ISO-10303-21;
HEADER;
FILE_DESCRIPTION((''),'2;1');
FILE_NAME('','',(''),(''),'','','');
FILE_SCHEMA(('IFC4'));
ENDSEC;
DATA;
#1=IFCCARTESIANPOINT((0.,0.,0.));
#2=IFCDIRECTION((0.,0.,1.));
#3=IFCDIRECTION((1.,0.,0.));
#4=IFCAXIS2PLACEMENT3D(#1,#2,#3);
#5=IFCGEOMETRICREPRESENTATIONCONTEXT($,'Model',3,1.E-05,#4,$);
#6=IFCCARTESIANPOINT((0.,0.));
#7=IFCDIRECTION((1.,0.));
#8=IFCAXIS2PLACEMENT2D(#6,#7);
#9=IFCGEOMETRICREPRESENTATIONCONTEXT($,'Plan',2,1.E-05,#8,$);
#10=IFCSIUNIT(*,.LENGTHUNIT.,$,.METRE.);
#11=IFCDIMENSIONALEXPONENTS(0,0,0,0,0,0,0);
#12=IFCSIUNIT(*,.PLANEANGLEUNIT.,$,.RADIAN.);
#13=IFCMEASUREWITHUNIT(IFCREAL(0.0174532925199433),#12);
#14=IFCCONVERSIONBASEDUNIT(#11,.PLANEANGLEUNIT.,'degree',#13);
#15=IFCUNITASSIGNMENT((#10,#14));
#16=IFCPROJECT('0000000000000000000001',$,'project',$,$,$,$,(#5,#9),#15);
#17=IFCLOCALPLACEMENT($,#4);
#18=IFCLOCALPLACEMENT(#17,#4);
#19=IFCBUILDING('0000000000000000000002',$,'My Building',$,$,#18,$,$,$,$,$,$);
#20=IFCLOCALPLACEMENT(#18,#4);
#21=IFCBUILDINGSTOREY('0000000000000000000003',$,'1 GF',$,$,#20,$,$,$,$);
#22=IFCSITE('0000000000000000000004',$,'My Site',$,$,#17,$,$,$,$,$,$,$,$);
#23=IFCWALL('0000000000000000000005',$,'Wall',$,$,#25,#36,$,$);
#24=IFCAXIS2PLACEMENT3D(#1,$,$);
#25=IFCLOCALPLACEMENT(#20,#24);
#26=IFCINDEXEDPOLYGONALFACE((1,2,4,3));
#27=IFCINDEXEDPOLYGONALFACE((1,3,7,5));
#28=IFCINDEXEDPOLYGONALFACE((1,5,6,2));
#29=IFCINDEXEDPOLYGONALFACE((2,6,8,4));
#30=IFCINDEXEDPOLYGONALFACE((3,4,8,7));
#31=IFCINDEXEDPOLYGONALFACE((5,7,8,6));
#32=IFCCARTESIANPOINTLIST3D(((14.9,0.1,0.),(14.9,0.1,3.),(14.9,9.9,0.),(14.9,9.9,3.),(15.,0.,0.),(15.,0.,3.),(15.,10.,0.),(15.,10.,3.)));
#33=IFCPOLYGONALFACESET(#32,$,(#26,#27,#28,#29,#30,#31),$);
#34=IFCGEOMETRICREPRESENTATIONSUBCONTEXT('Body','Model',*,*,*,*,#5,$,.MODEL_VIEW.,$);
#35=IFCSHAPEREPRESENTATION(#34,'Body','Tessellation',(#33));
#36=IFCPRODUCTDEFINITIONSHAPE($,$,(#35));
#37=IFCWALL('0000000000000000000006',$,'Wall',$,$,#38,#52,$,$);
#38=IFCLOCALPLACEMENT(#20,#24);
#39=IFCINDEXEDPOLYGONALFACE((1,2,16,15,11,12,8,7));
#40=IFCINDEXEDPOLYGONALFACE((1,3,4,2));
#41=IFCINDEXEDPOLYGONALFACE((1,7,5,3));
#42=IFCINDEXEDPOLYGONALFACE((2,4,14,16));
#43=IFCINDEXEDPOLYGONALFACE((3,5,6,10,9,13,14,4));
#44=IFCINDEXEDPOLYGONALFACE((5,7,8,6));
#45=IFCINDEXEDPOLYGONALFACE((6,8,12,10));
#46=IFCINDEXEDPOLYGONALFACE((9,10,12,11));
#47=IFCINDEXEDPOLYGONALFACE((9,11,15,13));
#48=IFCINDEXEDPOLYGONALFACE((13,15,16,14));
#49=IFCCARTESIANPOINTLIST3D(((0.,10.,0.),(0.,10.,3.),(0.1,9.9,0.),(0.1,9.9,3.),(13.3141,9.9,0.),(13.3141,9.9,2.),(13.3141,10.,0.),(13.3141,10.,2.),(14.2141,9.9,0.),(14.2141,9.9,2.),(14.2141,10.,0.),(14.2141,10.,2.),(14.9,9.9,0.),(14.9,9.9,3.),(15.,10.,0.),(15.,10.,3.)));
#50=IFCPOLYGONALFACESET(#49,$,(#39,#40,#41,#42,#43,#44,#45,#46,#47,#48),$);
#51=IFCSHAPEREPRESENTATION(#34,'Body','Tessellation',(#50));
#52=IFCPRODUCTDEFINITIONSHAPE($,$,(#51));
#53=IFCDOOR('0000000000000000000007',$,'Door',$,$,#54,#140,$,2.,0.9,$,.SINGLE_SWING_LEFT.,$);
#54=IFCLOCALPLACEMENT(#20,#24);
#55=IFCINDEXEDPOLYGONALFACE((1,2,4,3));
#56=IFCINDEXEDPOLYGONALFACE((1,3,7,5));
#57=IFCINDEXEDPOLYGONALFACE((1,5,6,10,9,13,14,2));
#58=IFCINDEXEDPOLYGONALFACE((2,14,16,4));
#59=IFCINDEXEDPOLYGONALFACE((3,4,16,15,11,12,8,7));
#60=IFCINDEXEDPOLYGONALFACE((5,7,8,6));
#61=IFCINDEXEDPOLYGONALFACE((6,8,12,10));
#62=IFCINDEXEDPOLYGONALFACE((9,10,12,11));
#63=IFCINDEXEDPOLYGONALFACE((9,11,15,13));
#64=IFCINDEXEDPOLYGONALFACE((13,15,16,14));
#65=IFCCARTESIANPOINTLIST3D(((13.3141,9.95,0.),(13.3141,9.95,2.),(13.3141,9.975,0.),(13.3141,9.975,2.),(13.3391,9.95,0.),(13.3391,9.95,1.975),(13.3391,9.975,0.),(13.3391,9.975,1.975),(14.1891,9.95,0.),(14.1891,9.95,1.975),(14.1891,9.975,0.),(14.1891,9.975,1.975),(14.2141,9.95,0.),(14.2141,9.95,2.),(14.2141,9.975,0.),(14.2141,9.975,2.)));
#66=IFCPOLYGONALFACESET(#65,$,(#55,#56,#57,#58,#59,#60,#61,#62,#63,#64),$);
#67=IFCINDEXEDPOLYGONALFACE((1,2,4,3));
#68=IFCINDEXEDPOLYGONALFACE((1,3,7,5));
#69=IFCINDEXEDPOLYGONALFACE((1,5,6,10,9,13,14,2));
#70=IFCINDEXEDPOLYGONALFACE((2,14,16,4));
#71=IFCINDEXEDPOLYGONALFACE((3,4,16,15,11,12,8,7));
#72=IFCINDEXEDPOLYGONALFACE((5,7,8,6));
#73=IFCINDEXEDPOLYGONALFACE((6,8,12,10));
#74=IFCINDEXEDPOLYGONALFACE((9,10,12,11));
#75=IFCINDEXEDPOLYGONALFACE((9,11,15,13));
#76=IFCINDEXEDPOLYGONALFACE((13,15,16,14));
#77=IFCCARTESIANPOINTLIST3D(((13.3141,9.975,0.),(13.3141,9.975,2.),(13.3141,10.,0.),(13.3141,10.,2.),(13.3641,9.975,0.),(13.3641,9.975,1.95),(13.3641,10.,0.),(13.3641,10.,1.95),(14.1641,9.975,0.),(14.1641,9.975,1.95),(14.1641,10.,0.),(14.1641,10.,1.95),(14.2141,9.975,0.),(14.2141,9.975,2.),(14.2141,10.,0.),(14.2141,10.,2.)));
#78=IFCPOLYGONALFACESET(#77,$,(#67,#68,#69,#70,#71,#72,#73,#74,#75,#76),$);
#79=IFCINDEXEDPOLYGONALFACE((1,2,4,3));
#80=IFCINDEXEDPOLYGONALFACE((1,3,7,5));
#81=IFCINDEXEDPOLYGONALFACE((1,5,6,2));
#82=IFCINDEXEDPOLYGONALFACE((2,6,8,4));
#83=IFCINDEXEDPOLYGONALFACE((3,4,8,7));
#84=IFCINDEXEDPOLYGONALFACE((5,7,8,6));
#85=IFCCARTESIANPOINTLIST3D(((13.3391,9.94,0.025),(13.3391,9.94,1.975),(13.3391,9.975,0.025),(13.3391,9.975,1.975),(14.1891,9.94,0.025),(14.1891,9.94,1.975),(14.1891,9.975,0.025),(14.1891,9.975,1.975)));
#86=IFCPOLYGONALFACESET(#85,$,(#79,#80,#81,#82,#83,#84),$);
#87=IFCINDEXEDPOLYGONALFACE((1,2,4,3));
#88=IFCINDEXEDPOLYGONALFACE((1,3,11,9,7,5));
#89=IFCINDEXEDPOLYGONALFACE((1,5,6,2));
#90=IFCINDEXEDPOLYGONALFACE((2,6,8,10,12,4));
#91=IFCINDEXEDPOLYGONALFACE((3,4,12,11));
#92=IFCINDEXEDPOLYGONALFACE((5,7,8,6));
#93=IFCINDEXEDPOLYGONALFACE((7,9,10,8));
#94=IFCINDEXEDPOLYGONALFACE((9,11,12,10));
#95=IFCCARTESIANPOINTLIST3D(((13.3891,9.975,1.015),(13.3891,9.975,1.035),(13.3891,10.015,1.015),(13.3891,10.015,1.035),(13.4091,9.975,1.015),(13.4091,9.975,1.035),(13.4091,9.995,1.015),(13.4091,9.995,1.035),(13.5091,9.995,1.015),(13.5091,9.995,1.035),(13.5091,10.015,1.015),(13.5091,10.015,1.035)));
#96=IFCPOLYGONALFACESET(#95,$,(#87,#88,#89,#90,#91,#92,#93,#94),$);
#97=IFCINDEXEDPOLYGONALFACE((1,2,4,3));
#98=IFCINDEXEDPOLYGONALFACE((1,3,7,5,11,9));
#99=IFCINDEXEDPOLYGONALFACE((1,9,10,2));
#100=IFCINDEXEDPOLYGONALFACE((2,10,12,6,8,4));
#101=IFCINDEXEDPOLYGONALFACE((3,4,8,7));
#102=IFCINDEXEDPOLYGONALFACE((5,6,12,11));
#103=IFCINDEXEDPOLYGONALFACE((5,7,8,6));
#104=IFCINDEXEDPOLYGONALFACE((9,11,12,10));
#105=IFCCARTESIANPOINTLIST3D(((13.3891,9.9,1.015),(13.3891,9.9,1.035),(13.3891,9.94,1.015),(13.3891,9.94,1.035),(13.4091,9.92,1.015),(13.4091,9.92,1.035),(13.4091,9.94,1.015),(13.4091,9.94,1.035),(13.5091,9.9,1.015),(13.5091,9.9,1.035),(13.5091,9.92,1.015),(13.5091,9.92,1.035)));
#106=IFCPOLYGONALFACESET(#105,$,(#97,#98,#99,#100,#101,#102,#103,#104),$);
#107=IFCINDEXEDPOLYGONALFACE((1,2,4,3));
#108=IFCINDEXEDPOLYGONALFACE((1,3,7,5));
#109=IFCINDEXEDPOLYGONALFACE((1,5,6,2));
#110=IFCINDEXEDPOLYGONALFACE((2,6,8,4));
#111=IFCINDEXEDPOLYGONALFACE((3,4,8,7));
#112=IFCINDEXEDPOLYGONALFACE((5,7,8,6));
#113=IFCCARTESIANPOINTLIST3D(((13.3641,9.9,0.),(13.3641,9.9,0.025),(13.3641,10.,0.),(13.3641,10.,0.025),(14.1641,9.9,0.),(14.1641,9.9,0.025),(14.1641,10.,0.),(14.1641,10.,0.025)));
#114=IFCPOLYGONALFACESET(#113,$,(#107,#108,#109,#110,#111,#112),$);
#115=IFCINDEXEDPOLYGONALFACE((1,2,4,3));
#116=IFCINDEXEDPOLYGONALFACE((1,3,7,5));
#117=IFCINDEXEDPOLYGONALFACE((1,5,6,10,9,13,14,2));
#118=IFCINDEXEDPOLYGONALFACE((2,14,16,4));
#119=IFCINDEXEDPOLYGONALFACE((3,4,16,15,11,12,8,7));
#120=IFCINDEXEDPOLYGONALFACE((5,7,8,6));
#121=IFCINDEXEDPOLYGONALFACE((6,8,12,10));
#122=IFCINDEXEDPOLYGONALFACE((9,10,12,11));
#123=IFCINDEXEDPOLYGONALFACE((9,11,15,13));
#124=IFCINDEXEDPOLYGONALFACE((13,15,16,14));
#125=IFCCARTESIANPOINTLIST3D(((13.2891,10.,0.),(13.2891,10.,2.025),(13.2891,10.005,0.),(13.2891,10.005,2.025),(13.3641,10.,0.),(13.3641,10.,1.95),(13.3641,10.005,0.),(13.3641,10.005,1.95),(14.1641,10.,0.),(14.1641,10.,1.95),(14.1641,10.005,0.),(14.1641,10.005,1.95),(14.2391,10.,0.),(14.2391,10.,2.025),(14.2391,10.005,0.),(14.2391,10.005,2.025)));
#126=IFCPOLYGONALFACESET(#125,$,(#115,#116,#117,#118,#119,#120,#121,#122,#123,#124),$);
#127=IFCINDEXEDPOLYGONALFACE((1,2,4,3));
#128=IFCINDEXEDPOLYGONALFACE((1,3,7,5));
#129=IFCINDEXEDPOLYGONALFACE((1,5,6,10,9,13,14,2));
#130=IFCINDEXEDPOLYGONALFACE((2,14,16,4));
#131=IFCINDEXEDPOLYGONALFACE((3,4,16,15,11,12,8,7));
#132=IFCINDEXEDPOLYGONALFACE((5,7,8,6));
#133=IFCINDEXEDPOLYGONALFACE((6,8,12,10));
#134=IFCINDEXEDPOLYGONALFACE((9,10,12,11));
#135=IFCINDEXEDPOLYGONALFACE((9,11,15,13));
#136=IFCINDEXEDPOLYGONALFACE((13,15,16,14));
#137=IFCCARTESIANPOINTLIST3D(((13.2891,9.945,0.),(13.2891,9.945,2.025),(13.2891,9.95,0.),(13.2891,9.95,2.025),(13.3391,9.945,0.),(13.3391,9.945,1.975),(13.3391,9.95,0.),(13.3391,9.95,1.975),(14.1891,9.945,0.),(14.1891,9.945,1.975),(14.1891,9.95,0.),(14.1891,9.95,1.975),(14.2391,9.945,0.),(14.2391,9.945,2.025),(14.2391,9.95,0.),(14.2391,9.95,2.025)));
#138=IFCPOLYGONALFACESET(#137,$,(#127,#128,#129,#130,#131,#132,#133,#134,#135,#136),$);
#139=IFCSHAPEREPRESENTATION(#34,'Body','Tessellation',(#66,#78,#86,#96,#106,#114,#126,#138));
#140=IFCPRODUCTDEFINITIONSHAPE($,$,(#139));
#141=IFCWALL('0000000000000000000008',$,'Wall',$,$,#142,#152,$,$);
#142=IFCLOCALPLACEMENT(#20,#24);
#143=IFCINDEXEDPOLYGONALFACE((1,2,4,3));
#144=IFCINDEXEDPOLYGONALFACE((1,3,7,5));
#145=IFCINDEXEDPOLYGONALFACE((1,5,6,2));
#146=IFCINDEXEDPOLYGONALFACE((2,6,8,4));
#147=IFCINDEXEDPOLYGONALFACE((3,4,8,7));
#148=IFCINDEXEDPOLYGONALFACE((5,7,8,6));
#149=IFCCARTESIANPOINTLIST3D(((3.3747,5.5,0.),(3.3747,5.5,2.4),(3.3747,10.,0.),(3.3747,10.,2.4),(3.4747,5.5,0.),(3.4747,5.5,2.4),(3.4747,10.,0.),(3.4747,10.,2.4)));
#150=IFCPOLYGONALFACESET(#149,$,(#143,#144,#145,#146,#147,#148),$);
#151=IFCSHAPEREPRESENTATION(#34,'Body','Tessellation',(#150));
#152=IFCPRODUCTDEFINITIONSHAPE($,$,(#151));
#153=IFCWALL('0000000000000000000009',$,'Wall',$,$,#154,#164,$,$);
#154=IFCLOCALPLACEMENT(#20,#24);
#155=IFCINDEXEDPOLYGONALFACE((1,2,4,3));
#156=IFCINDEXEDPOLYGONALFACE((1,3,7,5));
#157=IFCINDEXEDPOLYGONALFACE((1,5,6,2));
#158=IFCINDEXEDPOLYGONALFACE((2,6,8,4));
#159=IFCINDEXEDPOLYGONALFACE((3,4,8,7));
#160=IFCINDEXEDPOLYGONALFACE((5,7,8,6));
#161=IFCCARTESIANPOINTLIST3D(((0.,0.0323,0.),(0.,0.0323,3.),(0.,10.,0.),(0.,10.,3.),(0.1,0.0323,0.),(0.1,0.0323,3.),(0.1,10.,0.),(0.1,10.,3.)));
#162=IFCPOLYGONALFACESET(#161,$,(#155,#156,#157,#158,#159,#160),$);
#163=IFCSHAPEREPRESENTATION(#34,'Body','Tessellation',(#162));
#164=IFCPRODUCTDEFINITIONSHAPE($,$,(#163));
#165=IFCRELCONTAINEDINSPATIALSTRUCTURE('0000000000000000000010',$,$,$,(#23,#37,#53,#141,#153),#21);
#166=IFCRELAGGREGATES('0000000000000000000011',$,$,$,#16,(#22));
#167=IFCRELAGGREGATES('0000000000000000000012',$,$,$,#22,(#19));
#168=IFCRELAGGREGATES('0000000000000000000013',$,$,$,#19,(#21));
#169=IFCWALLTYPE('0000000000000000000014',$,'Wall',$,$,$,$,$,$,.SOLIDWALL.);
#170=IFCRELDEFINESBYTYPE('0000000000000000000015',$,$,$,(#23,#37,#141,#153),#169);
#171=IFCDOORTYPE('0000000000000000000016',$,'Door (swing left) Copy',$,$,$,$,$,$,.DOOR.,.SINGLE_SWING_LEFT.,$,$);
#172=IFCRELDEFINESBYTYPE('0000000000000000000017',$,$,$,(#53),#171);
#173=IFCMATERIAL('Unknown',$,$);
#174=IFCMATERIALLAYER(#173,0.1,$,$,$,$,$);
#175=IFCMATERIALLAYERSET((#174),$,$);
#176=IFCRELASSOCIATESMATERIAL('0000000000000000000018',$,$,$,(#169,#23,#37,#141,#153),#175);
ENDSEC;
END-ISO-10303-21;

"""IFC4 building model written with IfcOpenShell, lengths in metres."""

from ifc_helpers import new_model, entity, si_unit, converted_unit, frame, origin_with_axes, origin_2d_with_axis, place, context, subcontext, project, spatial, line, indexed_curve, outline, extrude, shape, source, transform, mapped, material, layer, layer_set, layer_usage, type_object, type_shapes, element, fill, save


model = new_model("IFC4")

# Units and contexts
model_context = context("Model", 3, precision=1e-05, world=origin_with_axes())
plan_context = context("Plan", 2, precision=1e-05, world=origin_2d_with_axis())
body_context_1 = subcontext(model_context, "Body", "Model", "MODEL_VIEW")
body_context_2 = subcontext(plan_context, "Body", "Plan", "PLAN_VIEW")
ifc_project = project(units=[si_unit("LENGTHUNIT", "METRE"), converted_unit("PLANEANGLEUNIT", "degree", entity("IfcReal", 0.0174532925199433), si_unit("PLANEANGLEUNIT", "RADIAN"), dimensions=[0, 0, 0, 0, 0, 0, 0])], contexts=[model_context, plan_context])

# Site, building, storey
site_placement = place(None, origin_with_axes())
site = spatial("IfcSite", under=ifc_project, at=site_placement, Name="My Site")
building_placement = place(site_placement, origin_with_axes())
building = spatial("IfcBuilding", under=site, at=building_placement, Name="My Building")
storey_placement = place(building_placement, origin_with_axes())
storey = spatial("IfcBuildingStorey", under=building, at=storey_placement, Name="1 GF")

# Shared definitions
ifc_material = material(Name="Unknown")

# Shared definitions
ifc_layer_1 = layer(ifc_material, 0.1)
ifc_layer_set_1 = layer_set([ifc_layer_1])
wall_type = type_object("IfcWallType", Name="Wall", PredefinedType="SOLIDWALL", material=ifc_layer_set_1)

# Wall
ifc_layer_usage_1 = layer_usage(ifc_layer_set_1, "AXIS2", "POSITIVE", 0.0)
wall_1_placement = place(storey_placement, frame((15.0, 0.0, 0.0), z_axis=(0.0, 0.0, 1.0), x_axis=(0.0, 1.0, 0.0)))
element("IfcWall", 1, at=wall_1_placement, inside=storey, type_object=wall_type, material=ifc_layer_usage_1, Name="Wall", context=body_context_1, shape_type="SweptSolid", body=[
    extrude(outline(indexed_curve([(0.0, 0.0), (0.1, 0.1), (9.9, 0.1), (10.0, 0.0)], segments=[line(1, 2, 3, 4, 1)])), origin_with_axes(), (0.0, 0.0, 1.0), 3.0),
])

# Wall, opening, door
ifc_layer_usage_2 = layer_usage(ifc_layer_set_1, "AXIS2", "POSITIVE", 0.0)
wall_2_placement = place(storey_placement, frame((15.0, 10.0, 0.0), z_axis=(0.0, 0.0, 1.0), x_axis=(-1.0, 0.0, 0.0)))
wall_2 = element("IfcWall", 2, at=wall_2_placement, inside=storey, type_object=wall_type, material=ifc_layer_usage_2, Name="Wall", context=body_context_1, shape_type="SweptSolid", body=[
    extrude(outline(indexed_curve([(0.0, 0.0), (0.1, 0.1), (14.9, 0.1), (15.0, 0.0)], segments=[line(1, 2, 3, 4, 1)])), origin_with_axes(), (0.0, 0.0, 1.0), 3.0),
])
shared_shape_1 = source(origin_with_axes(), body_context_1, "Body", "SweptSolid", [
    extrude(outline(indexed_curve([(0.0, 0.0), (0.9, 0.0), (0.9, 2.0), (0.0, 2.0)], segments=[line(1, 2, 3, 4, 1)])), frame((0.0, -0.6, 0.0), z_axis=(0.0, -1.0, 0.0), x_axis=(1.0, 0.0, 0.0)), (0.0, 0.0, -1.0), 1.2),
])
opening_1_placement = place(wall_2_placement, frame((0.7859, 0.0, 0.0), z_axis=(0.0, 0.0, 1.0), x_axis=(1.0, 0.0, 0.0)))
opening_1 = element("IfcOpeningElement", 3, at=opening_1_placement, cuts=wall_2, PredefinedType="OPENING", context=body_context_1, shape_type="MappedRepresentation", body=[
    mapped(shared_shape_1, transform((0.0, 0.0, 0.0), x_axis=(1.0, 0.0, 0.0), y_axis=(0.0, 1.0, 0.0), z_axis=(0.0, 0.0, 1.0), scale=1.0)),
])
door_type_1 = type_object("IfcDoorType", Name="Door (swing left) Copy", OperationType="SINGLE_SWING_LEFT", PredefinedType="DOOR")
shared_shape_2 = source(origin_with_axes(), body_context_1, "Body", "SweptSolid", [
    extrude(outline(indexed_curve([(0.0, 0.0), (0.0, 2.0), (0.9, 2.0), (0.9, 0.0), (0.875, 0.0), (0.875, 1.975), (0.025, 1.975), (0.025, 0.0)], segments=[line(1, 2, 3, 4, 5, 6, 7, 8, 1)])), frame((0.0, 0.025, 0.0), z_axis=(0.0, -1.0, 0.0), x_axis=(1.0, 0.0, 0.0)), (0.0, 0.0, -1.0), 0.025),
    extrude(outline(indexed_curve([(0.0, 0.0), (0.0, 2.0), (0.9, 2.0), (0.9, 0.0), (0.85, 0.0), (0.85, 1.95), (0.05, 1.95), (0.05, 0.0)], segments=[line(1, 2, 3, 4, 5, 6, 7, 8, 1)])), frame((0.0, 0.0, 0.0), z_axis=(0.0, -1.0, 0.0), x_axis=(1.0, 0.0, 0.0)), (0.0, 0.0, -1.0), 0.025),
    extrude(outline(indexed_curve([(0.0, 0.0), (0.85, 0.0), (0.85, 0.035), (0.0, 0.035)], segments=[line(1, 2, 3, 4, 1)])), frame((0.025, 0.025, 0.025), z_axis=(0.0, 0.0, 1.0), x_axis=(1.0, 0.0, 0.0)), (0.0, 0.0, 1.0), 1.95),
    extrude(outline(indexed_curve([(0.0, 0.0), (0.0, -0.04), (-0.12, -0.04), (-0.12, -0.02), (-0.02, -0.02), (-0.02, 0.0)], segments=[line(1, 2, 3, 4, 5, 6, 1)])), frame((0.825, 0.025, 1.015), z_axis=(0.0, 0.0, 1.0), x_axis=(1.0, 0.0, 0.0)), (0.0, 0.0, 1.0), 0.02),
    extrude(outline(indexed_curve([(0.0, 0.0), (0.0, 0.04), (-0.12, 0.04), (-0.12, 0.02), (-0.02, 0.02), (-0.02, 0.0)], segments=[line(1, 2, 3, 4, 5, 6, 1)])), frame((0.825, 0.06, 1.015), z_axis=(0.0, 0.0, 1.0), x_axis=(1.0, 0.0, 0.0)), (0.0, 0.0, 1.0), 0.02),
    extrude(outline(indexed_curve([(0.0, 0.0), (0.8, 0.0), (0.8, 0.1), (0.0, 0.1)], segments=[line(1, 2, 3, 4, 1)])), frame((0.05, 0.0, 0.0), z_axis=(0.0, 0.0, 1.0), x_axis=(1.0, 0.0, 0.0)), (0.0, 0.0, 1.0), 0.025),
    extrude(outline(indexed_curve([(0.0, 0.0), (0.0, 2.025), (0.95, 2.025), (0.95, 0.0), (0.875, 0.0), (0.875, 1.95), (0.075, 1.95), (0.075, 0.0)], segments=[line(1, 2, 3, 4, 5, 6, 7, 8, 1)])), frame((-0.025, -0.005, 0.0), z_axis=(0.0, -1.0, 0.0), x_axis=(1.0, 0.0, 0.0)), (0.0, 0.0, -1.0), 0.005),
    extrude(outline(indexed_curve([(0.0, 0.0), (0.0, 2.025), (0.95, 2.025), (0.95, 0.0), (0.9, 0.0), (0.9, 1.975), (0.05, 1.975), (0.05, 0.0)], segments=[line(1, 2, 3, 4, 5, 6, 7, 8, 1)])), frame((-0.025, 0.05, 0.0), z_axis=(0.0, -1.0, 0.0), x_axis=(1.0, 0.0, 0.0)), (0.0, 0.0, -1.0), 0.005),
])
shared_shape_3 = source(origin_with_axes(), body_context_2, "Body", "Curve2D", [
    entity("IfcIndexedPolyCurve", entity("IfcCartesianPointList2D", [[0.0, 0.0], [0.0, 0.05], [0.025, 0.05], [0.025, 0.025], [0.05, 0.025], [0.05, 0.0]]), [entity("IfcLineIndex", [1, 2, 3, 4, 5, 6, 1])]),
    entity("IfcIndexedPolyCurve", entity("IfcCartesianPointList2D", [[0.9, 0.0], [0.9, 0.05], [0.875, 0.05], [0.875, 0.025], [0.85, 0.025], [0.85, 0.0]]), [entity("IfcLineIndex", [1, 2, 3, 4, 5, 6, 1])]),
    entity("IfcTrimmedCurve", entity("IfcEllipse", entity("IfcAxis2Placement2D", entity("IfcCartesianPoint", [0.06, 0.05]), entity("IfcDirection", [1.0, 0.0])), 0.815, 0.85), [entity("IfcCartesianPoint", [0.875, 0.05])], [entity("IfcCartesianPoint", [0.06, 0.9])], True, "CARTESIAN"),
    entity("IfcIndexedPolyCurve", entity("IfcCartesianPointList2D", [[0.025, 0.05], [0.06, 0.05], [0.06, 0.9], [0.025, 0.9]]), [entity("IfcLineIndex", [1, 2, 3, 4, 1])]),
])
type_shapes(door_type_1, [shared_shape_2, shared_shape_3])
door_1_placement = place(opening_1_placement, frame((0.0, 0.0, 0.0), z_axis=(0.0, 0.0, 1.0), x_axis=(1.0, 0.0, 0.0)))
door_1 = element("IfcDoor", 4, at=door_1_placement, inside=storey, type_object=door_type_1, Name="Door", OperationType="SINGLE_SWING_LEFT", OverallHeight=2.0, OverallWidth=0.9, shapes=[
    shape(body_context_1, "Body", "MappedRepresentation", [mapped(shared_shape_2, transform((0.0, 0.0, 0.0), x_axis=(1.0, 0.0, 0.0), y_axis=(0.0, 1.0, 0.0), z_axis=(0.0, 0.0, 1.0), scale=1.0))]),
    shape(body_context_2, "Body", "MappedRepresentation", [mapped(shared_shape_3, transform((0.0, 0.0, 0.0), x_axis=(1.0, 0.0, 0.0), y_axis=(0.0, 1.0, 0.0), z_axis=(0.0, 0.0, 1.0), scale=1.0))]),
])
fill(opening_1, door_1)

# Walls
ifc_layer_usage_3 = layer_usage(ifc_layer_set_1, "AXIS2", "POSITIVE", 0.0)
wall_3_placement = place(storey_placement, frame((3.4747, 5.5, 0.0), z_axis=(0.0, 0.0, 1.0), x_axis=(0.0, 1.0, 0.0)))
element("IfcWall", 5, at=wall_3_placement, inside=storey, type_object=wall_type, material=ifc_layer_usage_3, Name="Wall", context=body_context_1, shape_type="SweptSolid", body=[
    extrude(outline(indexed_curve([(0.0, 0.0), (0.0, 0.1), (4.5, 0.1), (4.5, 0.0)], segments=[line(1, 2, 3, 4, 1)])), origin_with_axes(), (0.0, 0.0, 1.0), 2.4),
])
ifc_layer_usage_4 = layer_usage(ifc_layer_set_1, "AXIS2", "POSITIVE", 0.0)
wall_4_placement = place(storey_placement, frame((0.0, 10.0, 0.0), z_axis=(0.0, 0.0, 1.0), x_axis=(0.0, -1.0, 0.0)))
element("IfcWall", 6, at=wall_4_placement, inside=storey, type_object=wall_type, material=ifc_layer_usage_4, Name="Wall", context=body_context_1, shape_type="SweptSolid", body=[
    extrude(outline(indexed_curve([(0.0, 0.0), (0.0, 0.1), (9.9677, 0.1), (9.9677, 0.0)], segments=[line(1, 2, 3, 4, 1)])), origin_with_axes(), (0.0, 0.0, 1.0), 3.0),
])

save(model, "model.ifc")
